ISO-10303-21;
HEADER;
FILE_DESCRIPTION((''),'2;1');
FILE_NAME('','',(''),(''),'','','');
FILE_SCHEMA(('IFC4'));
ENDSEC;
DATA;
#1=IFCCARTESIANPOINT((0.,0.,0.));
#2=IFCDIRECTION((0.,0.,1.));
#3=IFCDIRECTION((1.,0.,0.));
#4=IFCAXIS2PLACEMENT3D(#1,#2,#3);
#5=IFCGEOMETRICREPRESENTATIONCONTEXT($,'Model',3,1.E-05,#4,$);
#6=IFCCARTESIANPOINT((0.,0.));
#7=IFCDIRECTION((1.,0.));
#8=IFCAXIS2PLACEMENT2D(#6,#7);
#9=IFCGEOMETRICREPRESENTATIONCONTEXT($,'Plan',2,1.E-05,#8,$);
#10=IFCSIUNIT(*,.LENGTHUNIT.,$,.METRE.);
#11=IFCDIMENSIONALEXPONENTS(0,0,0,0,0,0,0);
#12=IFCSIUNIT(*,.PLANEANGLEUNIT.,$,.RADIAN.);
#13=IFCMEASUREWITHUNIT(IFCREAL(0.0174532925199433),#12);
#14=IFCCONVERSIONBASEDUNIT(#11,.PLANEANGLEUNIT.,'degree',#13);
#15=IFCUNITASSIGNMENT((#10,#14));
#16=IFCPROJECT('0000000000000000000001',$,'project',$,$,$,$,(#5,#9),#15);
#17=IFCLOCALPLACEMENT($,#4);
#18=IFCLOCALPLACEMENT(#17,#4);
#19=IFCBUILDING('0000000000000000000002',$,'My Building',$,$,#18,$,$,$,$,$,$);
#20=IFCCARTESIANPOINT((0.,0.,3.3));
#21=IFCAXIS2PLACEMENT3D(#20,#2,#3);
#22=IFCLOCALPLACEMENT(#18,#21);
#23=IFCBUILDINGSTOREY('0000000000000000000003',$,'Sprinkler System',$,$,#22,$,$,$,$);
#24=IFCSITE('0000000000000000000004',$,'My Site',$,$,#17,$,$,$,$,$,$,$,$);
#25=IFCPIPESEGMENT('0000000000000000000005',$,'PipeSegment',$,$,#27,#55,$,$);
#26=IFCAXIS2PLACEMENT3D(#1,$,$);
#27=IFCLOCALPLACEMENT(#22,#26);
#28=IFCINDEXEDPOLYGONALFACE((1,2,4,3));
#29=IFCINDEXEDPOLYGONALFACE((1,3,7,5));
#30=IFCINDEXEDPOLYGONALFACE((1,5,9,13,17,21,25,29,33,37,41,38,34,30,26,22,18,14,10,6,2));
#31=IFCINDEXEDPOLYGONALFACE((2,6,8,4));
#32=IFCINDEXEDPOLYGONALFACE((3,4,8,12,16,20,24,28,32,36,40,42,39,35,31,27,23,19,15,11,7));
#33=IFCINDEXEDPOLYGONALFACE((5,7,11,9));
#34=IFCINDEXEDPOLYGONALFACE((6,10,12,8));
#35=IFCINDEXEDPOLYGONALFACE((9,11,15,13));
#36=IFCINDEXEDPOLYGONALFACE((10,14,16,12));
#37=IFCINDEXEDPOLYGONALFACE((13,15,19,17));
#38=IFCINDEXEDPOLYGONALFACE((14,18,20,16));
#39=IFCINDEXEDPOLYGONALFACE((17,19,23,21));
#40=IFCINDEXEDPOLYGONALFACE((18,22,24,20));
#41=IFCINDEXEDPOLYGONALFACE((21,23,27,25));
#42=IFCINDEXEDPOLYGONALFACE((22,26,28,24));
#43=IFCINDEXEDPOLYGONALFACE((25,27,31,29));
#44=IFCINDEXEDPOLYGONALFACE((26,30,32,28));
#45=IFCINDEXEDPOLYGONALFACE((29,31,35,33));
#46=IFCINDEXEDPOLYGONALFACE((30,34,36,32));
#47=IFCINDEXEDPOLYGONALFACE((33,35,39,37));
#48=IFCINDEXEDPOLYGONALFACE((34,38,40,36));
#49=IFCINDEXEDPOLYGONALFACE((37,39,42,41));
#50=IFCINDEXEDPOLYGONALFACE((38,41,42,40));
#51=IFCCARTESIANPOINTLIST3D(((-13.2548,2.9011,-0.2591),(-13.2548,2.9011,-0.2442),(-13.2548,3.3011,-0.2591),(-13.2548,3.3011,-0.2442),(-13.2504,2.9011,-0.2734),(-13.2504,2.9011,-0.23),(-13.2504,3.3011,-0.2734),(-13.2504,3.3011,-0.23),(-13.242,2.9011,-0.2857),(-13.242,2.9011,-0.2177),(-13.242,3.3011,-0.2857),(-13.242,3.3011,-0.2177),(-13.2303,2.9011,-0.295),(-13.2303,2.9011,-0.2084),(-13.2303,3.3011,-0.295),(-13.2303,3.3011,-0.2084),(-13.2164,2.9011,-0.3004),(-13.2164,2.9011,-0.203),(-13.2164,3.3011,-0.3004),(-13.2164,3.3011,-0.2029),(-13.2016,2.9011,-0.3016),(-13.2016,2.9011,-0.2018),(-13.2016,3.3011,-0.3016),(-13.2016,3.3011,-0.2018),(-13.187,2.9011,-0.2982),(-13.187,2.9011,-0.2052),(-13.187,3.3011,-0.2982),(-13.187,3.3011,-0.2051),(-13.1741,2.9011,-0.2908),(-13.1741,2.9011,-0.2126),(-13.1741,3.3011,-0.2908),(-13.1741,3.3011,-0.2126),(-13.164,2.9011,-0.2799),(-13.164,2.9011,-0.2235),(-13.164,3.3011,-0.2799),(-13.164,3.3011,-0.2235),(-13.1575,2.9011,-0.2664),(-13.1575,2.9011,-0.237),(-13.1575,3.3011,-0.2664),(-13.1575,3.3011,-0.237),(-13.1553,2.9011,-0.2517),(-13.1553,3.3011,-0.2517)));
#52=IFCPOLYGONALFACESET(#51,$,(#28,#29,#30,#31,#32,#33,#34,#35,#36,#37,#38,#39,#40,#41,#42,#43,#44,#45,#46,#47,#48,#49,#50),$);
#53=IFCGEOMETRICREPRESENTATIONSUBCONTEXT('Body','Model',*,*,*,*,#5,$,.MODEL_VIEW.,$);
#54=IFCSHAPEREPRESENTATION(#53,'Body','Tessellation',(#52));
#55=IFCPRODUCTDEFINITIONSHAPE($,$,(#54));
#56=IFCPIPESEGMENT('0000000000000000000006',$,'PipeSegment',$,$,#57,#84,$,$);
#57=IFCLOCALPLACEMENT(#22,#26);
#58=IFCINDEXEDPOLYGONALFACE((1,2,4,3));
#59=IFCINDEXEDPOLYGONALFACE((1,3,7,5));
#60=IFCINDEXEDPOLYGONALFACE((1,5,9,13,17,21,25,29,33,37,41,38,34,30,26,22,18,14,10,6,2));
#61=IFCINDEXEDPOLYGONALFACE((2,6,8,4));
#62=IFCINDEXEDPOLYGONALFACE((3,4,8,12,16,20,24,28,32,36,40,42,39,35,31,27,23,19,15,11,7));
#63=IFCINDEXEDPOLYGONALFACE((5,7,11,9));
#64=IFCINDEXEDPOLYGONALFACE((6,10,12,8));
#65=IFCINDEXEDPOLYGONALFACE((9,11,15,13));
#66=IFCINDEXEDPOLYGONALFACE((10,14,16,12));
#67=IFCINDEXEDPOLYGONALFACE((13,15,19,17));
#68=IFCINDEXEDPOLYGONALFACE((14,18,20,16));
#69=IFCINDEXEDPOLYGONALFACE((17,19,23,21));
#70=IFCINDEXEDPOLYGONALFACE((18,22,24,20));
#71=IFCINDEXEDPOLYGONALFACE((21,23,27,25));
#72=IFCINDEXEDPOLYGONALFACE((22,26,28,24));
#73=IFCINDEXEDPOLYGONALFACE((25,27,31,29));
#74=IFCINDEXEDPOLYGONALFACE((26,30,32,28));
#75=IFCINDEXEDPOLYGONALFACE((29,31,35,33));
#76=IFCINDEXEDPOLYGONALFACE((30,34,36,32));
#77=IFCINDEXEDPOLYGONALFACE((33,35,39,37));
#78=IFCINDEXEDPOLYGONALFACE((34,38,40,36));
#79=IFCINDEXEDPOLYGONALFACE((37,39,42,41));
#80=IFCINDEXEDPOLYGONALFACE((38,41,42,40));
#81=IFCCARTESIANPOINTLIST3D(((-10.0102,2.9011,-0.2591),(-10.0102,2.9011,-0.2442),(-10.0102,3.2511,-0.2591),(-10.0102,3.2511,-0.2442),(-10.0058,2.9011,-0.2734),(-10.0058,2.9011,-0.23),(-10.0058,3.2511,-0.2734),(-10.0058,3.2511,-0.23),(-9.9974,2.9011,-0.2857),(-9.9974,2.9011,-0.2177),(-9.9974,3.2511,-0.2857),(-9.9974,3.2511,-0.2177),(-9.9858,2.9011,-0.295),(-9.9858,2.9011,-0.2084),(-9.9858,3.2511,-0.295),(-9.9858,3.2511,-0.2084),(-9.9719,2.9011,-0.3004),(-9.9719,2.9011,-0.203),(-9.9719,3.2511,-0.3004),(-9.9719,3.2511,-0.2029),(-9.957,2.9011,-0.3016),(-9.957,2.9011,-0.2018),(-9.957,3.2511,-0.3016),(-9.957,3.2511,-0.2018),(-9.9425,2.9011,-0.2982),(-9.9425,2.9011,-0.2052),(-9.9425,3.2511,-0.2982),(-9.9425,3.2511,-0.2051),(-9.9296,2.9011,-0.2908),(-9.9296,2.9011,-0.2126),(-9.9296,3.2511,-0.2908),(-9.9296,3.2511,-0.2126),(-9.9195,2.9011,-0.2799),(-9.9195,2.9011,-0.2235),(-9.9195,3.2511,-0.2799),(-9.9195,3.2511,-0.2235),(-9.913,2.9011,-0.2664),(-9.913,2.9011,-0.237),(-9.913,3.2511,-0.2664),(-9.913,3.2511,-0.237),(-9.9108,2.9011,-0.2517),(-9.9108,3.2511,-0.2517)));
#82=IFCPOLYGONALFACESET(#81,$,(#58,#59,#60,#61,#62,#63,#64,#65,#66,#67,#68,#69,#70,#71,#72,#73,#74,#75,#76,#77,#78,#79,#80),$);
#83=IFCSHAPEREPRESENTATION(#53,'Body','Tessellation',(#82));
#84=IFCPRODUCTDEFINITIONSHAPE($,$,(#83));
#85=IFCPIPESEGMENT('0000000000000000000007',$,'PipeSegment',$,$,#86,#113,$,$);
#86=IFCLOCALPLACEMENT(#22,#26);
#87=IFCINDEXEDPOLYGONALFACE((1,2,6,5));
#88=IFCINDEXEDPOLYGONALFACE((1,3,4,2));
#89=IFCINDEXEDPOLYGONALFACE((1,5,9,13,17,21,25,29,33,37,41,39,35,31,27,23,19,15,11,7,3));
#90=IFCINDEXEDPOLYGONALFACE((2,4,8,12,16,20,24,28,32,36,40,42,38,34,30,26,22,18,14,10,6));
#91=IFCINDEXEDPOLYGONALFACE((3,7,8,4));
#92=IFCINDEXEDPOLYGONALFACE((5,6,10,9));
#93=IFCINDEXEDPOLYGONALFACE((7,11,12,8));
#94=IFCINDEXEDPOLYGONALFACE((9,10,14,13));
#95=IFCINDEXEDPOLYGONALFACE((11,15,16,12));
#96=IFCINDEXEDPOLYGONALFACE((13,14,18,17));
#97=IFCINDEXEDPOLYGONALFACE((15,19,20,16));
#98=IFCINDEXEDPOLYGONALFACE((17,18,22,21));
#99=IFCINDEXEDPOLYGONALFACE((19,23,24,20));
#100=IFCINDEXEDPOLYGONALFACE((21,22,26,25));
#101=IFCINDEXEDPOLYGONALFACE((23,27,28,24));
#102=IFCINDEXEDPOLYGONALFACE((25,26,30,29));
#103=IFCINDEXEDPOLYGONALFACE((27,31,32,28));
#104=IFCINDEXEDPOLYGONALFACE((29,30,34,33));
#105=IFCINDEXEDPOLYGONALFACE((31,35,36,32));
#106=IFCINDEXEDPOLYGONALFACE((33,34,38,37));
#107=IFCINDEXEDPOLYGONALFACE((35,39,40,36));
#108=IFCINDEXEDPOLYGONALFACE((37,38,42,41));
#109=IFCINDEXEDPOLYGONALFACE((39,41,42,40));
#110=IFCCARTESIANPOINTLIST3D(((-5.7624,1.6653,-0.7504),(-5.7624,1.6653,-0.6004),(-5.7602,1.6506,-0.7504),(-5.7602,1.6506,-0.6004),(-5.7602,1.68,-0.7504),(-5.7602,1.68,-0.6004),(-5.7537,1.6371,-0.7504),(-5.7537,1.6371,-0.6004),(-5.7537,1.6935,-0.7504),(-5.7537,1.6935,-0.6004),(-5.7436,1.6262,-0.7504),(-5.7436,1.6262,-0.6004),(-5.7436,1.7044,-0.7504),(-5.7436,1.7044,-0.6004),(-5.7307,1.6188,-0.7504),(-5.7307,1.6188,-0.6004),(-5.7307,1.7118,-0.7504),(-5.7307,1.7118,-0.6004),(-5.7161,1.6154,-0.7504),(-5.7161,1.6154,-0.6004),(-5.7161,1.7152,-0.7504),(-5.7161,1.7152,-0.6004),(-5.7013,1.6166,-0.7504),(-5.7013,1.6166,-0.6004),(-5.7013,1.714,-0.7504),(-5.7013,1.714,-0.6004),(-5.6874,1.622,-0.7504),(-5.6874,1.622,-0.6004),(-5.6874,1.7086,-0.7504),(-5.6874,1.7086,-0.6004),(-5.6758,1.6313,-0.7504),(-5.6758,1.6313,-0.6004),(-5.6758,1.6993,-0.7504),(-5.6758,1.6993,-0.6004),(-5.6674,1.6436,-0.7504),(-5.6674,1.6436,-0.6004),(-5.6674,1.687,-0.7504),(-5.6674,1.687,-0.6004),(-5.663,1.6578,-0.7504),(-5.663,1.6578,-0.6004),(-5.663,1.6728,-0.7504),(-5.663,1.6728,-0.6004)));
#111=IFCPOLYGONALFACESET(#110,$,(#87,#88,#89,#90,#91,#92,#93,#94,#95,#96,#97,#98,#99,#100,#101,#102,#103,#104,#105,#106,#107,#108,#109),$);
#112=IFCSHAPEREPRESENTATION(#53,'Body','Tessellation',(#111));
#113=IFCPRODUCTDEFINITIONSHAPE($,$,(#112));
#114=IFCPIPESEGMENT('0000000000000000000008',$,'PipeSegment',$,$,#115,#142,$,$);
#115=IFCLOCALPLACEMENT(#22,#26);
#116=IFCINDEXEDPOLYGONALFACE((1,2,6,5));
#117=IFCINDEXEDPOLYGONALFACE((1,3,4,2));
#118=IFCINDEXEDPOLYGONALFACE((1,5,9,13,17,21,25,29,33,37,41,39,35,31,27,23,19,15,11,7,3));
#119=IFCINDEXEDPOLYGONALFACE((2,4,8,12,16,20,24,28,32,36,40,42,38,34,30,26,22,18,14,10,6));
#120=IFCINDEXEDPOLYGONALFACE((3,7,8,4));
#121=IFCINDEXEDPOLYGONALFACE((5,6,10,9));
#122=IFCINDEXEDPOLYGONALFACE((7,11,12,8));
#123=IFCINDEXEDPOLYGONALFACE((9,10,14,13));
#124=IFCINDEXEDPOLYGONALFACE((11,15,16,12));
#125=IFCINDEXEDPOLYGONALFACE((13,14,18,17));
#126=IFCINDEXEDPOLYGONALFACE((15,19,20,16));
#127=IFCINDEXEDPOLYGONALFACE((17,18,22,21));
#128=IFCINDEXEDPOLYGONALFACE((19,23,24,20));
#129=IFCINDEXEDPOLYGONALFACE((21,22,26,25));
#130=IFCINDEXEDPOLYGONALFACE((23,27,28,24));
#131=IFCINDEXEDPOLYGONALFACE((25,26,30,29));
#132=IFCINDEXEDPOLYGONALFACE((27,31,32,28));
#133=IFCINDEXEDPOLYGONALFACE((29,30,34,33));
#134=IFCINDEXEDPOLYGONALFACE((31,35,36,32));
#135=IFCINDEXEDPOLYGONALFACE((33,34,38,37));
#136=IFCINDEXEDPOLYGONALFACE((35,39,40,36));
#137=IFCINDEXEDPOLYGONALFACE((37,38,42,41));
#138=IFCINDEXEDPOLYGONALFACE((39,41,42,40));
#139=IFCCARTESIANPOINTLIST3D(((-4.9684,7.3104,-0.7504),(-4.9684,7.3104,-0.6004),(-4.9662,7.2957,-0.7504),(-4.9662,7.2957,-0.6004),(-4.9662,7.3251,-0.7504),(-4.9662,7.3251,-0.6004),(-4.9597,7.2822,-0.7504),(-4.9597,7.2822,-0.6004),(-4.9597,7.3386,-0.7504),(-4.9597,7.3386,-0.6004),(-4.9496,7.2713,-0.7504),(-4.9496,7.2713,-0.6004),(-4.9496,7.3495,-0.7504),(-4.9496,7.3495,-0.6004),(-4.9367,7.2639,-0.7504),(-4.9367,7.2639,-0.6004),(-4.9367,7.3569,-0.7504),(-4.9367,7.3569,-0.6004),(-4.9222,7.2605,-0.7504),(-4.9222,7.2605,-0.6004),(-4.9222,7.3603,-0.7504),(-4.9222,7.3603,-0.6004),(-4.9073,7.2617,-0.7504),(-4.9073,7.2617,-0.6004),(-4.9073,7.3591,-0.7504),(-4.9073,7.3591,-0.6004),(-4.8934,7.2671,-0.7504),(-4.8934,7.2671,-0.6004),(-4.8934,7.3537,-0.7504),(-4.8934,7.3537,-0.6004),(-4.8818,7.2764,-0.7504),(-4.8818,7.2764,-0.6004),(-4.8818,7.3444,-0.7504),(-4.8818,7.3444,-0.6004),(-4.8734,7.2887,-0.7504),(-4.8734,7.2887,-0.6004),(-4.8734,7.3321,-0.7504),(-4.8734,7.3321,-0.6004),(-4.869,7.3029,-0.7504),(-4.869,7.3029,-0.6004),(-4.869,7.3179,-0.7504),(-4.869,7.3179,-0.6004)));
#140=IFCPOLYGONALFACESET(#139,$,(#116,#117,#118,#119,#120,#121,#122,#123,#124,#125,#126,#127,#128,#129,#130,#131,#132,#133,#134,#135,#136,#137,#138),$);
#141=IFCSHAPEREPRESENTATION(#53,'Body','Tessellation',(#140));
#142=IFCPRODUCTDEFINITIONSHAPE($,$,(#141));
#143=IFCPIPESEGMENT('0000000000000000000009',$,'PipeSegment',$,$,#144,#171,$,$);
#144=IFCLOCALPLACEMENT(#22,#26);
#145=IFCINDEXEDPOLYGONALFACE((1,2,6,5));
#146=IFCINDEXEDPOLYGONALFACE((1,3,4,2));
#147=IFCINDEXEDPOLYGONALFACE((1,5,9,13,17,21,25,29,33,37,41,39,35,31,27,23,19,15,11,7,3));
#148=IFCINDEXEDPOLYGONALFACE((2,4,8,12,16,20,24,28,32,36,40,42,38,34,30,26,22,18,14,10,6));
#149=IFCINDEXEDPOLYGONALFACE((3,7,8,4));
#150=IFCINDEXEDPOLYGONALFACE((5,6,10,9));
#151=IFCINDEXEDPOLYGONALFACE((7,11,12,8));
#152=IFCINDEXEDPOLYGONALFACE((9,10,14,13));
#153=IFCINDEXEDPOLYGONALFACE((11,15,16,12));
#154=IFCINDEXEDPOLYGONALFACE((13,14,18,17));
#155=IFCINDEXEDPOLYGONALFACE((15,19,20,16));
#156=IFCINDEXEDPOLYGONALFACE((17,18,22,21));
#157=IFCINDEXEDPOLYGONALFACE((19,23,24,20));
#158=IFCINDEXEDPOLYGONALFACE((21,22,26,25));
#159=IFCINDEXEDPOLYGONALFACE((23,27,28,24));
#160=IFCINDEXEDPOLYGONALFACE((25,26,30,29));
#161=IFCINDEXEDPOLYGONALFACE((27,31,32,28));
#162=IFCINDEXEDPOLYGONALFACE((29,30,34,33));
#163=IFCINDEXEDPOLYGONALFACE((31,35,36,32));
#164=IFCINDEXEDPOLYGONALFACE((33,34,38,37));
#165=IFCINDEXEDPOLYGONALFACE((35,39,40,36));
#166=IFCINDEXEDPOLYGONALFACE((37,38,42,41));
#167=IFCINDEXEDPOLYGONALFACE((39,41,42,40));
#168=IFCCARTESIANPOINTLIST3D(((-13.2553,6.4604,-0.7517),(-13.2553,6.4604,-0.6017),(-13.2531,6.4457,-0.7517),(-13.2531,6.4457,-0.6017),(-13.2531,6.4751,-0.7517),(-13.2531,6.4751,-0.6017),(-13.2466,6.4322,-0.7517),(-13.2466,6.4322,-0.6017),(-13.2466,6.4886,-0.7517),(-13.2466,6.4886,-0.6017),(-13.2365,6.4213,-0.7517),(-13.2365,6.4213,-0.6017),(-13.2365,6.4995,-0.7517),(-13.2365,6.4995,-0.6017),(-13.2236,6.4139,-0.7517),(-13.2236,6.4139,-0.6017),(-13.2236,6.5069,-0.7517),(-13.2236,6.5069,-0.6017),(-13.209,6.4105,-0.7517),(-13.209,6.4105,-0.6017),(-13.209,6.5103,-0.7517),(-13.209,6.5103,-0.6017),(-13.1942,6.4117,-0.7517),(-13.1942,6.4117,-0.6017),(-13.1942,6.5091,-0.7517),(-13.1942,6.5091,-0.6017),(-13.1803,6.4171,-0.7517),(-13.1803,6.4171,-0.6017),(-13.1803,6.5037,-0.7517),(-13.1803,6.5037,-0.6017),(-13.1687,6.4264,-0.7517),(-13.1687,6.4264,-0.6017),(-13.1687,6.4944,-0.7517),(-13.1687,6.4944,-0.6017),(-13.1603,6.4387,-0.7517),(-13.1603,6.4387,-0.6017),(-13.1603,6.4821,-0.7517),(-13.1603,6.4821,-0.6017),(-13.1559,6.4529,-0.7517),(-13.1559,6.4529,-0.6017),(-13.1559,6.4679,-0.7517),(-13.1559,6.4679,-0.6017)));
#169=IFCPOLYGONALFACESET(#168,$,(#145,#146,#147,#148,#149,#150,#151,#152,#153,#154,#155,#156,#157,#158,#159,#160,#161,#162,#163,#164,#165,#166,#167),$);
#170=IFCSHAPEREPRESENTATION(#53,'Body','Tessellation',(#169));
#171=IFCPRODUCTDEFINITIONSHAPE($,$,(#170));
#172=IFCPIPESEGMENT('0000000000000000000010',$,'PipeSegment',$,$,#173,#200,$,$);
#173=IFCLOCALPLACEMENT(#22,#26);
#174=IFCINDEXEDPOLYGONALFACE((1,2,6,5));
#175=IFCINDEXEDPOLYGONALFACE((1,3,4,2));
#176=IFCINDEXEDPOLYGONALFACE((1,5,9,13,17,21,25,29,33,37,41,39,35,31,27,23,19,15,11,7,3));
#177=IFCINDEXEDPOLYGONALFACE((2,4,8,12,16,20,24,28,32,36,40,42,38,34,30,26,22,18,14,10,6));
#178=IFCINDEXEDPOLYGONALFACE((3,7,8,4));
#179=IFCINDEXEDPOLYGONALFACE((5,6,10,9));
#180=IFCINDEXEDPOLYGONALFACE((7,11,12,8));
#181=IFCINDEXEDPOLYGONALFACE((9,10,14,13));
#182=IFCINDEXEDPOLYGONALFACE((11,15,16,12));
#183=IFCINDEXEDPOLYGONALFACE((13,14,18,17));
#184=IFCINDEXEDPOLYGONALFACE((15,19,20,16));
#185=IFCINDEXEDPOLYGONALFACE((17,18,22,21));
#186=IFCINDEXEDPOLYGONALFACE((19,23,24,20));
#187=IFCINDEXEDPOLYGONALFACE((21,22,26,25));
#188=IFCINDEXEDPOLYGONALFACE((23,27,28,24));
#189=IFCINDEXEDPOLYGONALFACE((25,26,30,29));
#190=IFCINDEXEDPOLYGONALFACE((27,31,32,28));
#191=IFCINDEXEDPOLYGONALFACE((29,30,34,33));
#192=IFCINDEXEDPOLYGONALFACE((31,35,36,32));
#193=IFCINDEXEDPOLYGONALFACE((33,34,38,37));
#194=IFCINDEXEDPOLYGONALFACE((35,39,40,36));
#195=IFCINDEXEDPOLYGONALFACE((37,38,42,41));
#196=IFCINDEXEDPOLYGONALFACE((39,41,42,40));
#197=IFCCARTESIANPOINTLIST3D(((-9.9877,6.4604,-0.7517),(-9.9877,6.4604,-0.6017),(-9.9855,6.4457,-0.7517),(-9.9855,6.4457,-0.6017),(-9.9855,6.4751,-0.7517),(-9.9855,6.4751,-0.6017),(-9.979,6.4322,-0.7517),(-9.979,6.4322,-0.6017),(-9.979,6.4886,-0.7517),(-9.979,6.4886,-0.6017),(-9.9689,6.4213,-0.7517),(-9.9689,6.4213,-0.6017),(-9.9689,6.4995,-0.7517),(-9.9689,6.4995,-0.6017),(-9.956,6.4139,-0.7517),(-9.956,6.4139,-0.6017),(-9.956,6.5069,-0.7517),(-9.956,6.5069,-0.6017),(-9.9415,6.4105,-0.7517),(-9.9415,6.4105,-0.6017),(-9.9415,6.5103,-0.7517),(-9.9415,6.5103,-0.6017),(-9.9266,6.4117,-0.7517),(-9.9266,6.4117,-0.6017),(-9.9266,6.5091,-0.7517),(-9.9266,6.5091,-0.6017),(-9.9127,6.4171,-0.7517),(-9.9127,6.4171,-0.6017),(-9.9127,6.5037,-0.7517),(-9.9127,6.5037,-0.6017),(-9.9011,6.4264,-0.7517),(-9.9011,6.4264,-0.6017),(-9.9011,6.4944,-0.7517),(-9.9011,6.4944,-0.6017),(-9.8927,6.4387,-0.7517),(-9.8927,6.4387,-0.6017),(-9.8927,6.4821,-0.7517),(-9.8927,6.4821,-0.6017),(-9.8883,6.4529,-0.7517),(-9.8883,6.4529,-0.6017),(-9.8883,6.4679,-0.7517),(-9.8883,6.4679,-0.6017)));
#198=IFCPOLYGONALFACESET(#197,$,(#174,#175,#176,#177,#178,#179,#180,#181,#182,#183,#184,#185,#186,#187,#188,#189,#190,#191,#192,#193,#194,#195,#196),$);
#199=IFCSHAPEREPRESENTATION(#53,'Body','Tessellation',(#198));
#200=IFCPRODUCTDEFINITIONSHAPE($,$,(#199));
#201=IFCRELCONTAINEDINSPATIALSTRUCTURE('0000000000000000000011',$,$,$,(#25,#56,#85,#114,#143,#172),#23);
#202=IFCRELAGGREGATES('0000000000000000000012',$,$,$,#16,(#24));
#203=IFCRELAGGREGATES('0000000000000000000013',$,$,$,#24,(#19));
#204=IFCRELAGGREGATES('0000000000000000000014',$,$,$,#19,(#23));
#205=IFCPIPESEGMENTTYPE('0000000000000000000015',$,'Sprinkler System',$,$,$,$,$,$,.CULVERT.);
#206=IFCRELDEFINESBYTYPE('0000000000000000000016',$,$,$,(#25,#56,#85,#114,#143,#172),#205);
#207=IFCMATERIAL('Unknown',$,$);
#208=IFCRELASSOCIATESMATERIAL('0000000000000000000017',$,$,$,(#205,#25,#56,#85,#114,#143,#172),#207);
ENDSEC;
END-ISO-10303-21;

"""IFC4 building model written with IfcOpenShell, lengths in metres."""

from ifc_helpers import new_model, entity, si_unit, converted_unit, frame, origin_with_axes, origin_2d_with_axis, place, context, subcontext, project, spatial, circle, extrude, material, material_profile, profile_set, profile_usage, type_object, element, save


model = new_model("IFC4")

# Units and contexts
model_context = context("Model", 3, precision=1e-05, world=origin_with_axes())
plan_context = context("Plan", 2, precision=1e-05, world=origin_2d_with_axis())
body_context = subcontext(model_context, "Body", "Model", "MODEL_VIEW")
ifc_project = project(units=[si_unit("LENGTHUNIT", "METRE"), converted_unit("PLANEANGLEUNIT", "degree", entity("IfcReal", 0.0174532925199433), si_unit("PLANEANGLEUNIT", "RADIAN"), dimensions=[0, 0, 0, 0, 0, 0, 0])], contexts=[model_context, plan_context])

# Site, building, storey
site_placement = place(None, origin_with_axes())
site = spatial("IfcSite", under=ifc_project, at=site_placement, Name="My Site")
building_placement = place(site_placement, origin_with_axes())
building = spatial("IfcBuilding", under=site, at=building_placement, Name="My Building")
storey_placement = place(building_placement, frame((0.0, 0.0, 3.3), z_axis=(0.0, 0.0, 1.0), x_axis=(1.0, 0.0, 0.0)))
storey = spatial("IfcBuildingStorey", under=building, at=storey_placement, Name="Sprinkler System")

# Pipe segments
ifc_material = material(Name="Unknown")
ifc_material_profile_1 = material_profile(ifc_material, circle(Radius=0.05))
ifc_profile_set_1 = profile_set([ifc_material_profile_1])
pipe_segment_type = type_object("IfcPipeSegmentType", Name="Sprinkler System", PredefinedType="CULVERT", material=ifc_profile_set_1)
ifc_profile_usage_1 = profile_usage(ifc_profile_set_1, cardinal=5)
pipe_segment_1_placement = place(storey_placement, frame((-13.2053, 3.3011, -0.2517), z_axis=(-0.000001, -1.0, -0.000012), x_axis=(1.0, -0.000001, 0.0)))
element("IfcPipeSegment", 1, at=pipe_segment_1_placement, inside=storey, type_object=pipe_segment_type, material=ifc_profile_usage_1, Name="PipeSegment", context=body_context, shape_type="SweptSolid", body=[
    extrude(circle(Radius=0.05), origin_with_axes(), (0.0, 0.0, 1.0), 0.4),
])
ifc_profile_usage_2 = profile_usage(ifc_profile_set_1, cardinal=5)
pipe_segment_2_placement = place(storey_placement, frame((-9.9608, 3.2511, -0.2517), z_axis=(-0.000001, -1.0, -0.000012), x_axis=(1.0, -0.000001, 0.0)))
element("IfcPipeSegment", 2, at=pipe_segment_2_placement, inside=storey, type_object=pipe_segment_type, material=ifc_profile_usage_2, Name="PipeSegment", context=body_context, shape_type="SweptSolid", body=[
    extrude(circle(Radius=0.05), origin_with_axes(), (0.0, 0.0, 1.0), 0.35),
])
ifc_profile_usage_3 = profile_usage(ifc_profile_set_1, cardinal=5)
pipe_segment_3_placement = place(storey_placement, frame((-5.7124, 1.6653, -0.6004), z_axis=(0.0, 0.0, -1.0), x_axis=(-1.0, 0.0, 0.0)))
element("IfcPipeSegment", 3, at=pipe_segment_3_placement, inside=storey, type_object=pipe_segment_type, material=ifc_profile_usage_3, Name="PipeSegment", context=body_context, shape_type="SweptSolid", body=[
    extrude(circle(Radius=0.05), origin_with_axes(), (0.0, 0.0, 1.0), 0.15),
])
ifc_profile_usage_4 = profile_usage(ifc_profile_set_1, cardinal=5)
pipe_segment_4_placement = place(storey_placement, frame((-4.9184, 7.3104, -0.6004), z_axis=(0.0, 0.0, -1.0), x_axis=(-1.0, 0.0, 0.0)))
element("IfcPipeSegment", 4, at=pipe_segment_4_placement, inside=storey, type_object=pipe_segment_type, material=ifc_profile_usage_4, Name="PipeSegment", context=body_context, shape_type="SweptSolid", body=[
    extrude(circle(Radius=0.05), origin_with_axes(), (0.0, 0.0, 1.0), 0.15),
])
ifc_profile_usage_5 = profile_usage(ifc_profile_set_1, cardinal=5)
pipe_segment_5_placement = place(storey_placement, frame((-13.2053, 6.4604, -0.6017), z_axis=(0.0, 0.0, -1.0), x_axis=(-1.0, 0.0, 0.0)))
element("IfcPipeSegment", 5, at=pipe_segment_5_placement, inside=storey, type_object=pipe_segment_type, material=ifc_profile_usage_5, Name="PipeSegment", context=body_context, shape_type="SweptSolid", body=[
    extrude(circle(Radius=0.05), origin_with_axes(), (0.0, 0.0, 1.0), 0.15),
])
ifc_profile_usage_6 = profile_usage(ifc_profile_set_1, cardinal=5)
pipe_segment_6_placement = place(storey_placement, frame((-9.9377, 6.4604, -0.6017), z_axis=(0.0, 0.0, -1.0), x_axis=(-1.0, 0.0, 0.0)))
element("IfcPipeSegment", 6, at=pipe_segment_6_placement, inside=storey, type_object=pipe_segment_type, material=ifc_profile_usage_6, Name="PipeSegment", context=body_context, shape_type="SweptSolid", body=[
    extrude(circle(Radius=0.05), origin_with_axes(), (0.0, 0.0, 1.0), 0.15),
])

save(model, "model.ifc")
